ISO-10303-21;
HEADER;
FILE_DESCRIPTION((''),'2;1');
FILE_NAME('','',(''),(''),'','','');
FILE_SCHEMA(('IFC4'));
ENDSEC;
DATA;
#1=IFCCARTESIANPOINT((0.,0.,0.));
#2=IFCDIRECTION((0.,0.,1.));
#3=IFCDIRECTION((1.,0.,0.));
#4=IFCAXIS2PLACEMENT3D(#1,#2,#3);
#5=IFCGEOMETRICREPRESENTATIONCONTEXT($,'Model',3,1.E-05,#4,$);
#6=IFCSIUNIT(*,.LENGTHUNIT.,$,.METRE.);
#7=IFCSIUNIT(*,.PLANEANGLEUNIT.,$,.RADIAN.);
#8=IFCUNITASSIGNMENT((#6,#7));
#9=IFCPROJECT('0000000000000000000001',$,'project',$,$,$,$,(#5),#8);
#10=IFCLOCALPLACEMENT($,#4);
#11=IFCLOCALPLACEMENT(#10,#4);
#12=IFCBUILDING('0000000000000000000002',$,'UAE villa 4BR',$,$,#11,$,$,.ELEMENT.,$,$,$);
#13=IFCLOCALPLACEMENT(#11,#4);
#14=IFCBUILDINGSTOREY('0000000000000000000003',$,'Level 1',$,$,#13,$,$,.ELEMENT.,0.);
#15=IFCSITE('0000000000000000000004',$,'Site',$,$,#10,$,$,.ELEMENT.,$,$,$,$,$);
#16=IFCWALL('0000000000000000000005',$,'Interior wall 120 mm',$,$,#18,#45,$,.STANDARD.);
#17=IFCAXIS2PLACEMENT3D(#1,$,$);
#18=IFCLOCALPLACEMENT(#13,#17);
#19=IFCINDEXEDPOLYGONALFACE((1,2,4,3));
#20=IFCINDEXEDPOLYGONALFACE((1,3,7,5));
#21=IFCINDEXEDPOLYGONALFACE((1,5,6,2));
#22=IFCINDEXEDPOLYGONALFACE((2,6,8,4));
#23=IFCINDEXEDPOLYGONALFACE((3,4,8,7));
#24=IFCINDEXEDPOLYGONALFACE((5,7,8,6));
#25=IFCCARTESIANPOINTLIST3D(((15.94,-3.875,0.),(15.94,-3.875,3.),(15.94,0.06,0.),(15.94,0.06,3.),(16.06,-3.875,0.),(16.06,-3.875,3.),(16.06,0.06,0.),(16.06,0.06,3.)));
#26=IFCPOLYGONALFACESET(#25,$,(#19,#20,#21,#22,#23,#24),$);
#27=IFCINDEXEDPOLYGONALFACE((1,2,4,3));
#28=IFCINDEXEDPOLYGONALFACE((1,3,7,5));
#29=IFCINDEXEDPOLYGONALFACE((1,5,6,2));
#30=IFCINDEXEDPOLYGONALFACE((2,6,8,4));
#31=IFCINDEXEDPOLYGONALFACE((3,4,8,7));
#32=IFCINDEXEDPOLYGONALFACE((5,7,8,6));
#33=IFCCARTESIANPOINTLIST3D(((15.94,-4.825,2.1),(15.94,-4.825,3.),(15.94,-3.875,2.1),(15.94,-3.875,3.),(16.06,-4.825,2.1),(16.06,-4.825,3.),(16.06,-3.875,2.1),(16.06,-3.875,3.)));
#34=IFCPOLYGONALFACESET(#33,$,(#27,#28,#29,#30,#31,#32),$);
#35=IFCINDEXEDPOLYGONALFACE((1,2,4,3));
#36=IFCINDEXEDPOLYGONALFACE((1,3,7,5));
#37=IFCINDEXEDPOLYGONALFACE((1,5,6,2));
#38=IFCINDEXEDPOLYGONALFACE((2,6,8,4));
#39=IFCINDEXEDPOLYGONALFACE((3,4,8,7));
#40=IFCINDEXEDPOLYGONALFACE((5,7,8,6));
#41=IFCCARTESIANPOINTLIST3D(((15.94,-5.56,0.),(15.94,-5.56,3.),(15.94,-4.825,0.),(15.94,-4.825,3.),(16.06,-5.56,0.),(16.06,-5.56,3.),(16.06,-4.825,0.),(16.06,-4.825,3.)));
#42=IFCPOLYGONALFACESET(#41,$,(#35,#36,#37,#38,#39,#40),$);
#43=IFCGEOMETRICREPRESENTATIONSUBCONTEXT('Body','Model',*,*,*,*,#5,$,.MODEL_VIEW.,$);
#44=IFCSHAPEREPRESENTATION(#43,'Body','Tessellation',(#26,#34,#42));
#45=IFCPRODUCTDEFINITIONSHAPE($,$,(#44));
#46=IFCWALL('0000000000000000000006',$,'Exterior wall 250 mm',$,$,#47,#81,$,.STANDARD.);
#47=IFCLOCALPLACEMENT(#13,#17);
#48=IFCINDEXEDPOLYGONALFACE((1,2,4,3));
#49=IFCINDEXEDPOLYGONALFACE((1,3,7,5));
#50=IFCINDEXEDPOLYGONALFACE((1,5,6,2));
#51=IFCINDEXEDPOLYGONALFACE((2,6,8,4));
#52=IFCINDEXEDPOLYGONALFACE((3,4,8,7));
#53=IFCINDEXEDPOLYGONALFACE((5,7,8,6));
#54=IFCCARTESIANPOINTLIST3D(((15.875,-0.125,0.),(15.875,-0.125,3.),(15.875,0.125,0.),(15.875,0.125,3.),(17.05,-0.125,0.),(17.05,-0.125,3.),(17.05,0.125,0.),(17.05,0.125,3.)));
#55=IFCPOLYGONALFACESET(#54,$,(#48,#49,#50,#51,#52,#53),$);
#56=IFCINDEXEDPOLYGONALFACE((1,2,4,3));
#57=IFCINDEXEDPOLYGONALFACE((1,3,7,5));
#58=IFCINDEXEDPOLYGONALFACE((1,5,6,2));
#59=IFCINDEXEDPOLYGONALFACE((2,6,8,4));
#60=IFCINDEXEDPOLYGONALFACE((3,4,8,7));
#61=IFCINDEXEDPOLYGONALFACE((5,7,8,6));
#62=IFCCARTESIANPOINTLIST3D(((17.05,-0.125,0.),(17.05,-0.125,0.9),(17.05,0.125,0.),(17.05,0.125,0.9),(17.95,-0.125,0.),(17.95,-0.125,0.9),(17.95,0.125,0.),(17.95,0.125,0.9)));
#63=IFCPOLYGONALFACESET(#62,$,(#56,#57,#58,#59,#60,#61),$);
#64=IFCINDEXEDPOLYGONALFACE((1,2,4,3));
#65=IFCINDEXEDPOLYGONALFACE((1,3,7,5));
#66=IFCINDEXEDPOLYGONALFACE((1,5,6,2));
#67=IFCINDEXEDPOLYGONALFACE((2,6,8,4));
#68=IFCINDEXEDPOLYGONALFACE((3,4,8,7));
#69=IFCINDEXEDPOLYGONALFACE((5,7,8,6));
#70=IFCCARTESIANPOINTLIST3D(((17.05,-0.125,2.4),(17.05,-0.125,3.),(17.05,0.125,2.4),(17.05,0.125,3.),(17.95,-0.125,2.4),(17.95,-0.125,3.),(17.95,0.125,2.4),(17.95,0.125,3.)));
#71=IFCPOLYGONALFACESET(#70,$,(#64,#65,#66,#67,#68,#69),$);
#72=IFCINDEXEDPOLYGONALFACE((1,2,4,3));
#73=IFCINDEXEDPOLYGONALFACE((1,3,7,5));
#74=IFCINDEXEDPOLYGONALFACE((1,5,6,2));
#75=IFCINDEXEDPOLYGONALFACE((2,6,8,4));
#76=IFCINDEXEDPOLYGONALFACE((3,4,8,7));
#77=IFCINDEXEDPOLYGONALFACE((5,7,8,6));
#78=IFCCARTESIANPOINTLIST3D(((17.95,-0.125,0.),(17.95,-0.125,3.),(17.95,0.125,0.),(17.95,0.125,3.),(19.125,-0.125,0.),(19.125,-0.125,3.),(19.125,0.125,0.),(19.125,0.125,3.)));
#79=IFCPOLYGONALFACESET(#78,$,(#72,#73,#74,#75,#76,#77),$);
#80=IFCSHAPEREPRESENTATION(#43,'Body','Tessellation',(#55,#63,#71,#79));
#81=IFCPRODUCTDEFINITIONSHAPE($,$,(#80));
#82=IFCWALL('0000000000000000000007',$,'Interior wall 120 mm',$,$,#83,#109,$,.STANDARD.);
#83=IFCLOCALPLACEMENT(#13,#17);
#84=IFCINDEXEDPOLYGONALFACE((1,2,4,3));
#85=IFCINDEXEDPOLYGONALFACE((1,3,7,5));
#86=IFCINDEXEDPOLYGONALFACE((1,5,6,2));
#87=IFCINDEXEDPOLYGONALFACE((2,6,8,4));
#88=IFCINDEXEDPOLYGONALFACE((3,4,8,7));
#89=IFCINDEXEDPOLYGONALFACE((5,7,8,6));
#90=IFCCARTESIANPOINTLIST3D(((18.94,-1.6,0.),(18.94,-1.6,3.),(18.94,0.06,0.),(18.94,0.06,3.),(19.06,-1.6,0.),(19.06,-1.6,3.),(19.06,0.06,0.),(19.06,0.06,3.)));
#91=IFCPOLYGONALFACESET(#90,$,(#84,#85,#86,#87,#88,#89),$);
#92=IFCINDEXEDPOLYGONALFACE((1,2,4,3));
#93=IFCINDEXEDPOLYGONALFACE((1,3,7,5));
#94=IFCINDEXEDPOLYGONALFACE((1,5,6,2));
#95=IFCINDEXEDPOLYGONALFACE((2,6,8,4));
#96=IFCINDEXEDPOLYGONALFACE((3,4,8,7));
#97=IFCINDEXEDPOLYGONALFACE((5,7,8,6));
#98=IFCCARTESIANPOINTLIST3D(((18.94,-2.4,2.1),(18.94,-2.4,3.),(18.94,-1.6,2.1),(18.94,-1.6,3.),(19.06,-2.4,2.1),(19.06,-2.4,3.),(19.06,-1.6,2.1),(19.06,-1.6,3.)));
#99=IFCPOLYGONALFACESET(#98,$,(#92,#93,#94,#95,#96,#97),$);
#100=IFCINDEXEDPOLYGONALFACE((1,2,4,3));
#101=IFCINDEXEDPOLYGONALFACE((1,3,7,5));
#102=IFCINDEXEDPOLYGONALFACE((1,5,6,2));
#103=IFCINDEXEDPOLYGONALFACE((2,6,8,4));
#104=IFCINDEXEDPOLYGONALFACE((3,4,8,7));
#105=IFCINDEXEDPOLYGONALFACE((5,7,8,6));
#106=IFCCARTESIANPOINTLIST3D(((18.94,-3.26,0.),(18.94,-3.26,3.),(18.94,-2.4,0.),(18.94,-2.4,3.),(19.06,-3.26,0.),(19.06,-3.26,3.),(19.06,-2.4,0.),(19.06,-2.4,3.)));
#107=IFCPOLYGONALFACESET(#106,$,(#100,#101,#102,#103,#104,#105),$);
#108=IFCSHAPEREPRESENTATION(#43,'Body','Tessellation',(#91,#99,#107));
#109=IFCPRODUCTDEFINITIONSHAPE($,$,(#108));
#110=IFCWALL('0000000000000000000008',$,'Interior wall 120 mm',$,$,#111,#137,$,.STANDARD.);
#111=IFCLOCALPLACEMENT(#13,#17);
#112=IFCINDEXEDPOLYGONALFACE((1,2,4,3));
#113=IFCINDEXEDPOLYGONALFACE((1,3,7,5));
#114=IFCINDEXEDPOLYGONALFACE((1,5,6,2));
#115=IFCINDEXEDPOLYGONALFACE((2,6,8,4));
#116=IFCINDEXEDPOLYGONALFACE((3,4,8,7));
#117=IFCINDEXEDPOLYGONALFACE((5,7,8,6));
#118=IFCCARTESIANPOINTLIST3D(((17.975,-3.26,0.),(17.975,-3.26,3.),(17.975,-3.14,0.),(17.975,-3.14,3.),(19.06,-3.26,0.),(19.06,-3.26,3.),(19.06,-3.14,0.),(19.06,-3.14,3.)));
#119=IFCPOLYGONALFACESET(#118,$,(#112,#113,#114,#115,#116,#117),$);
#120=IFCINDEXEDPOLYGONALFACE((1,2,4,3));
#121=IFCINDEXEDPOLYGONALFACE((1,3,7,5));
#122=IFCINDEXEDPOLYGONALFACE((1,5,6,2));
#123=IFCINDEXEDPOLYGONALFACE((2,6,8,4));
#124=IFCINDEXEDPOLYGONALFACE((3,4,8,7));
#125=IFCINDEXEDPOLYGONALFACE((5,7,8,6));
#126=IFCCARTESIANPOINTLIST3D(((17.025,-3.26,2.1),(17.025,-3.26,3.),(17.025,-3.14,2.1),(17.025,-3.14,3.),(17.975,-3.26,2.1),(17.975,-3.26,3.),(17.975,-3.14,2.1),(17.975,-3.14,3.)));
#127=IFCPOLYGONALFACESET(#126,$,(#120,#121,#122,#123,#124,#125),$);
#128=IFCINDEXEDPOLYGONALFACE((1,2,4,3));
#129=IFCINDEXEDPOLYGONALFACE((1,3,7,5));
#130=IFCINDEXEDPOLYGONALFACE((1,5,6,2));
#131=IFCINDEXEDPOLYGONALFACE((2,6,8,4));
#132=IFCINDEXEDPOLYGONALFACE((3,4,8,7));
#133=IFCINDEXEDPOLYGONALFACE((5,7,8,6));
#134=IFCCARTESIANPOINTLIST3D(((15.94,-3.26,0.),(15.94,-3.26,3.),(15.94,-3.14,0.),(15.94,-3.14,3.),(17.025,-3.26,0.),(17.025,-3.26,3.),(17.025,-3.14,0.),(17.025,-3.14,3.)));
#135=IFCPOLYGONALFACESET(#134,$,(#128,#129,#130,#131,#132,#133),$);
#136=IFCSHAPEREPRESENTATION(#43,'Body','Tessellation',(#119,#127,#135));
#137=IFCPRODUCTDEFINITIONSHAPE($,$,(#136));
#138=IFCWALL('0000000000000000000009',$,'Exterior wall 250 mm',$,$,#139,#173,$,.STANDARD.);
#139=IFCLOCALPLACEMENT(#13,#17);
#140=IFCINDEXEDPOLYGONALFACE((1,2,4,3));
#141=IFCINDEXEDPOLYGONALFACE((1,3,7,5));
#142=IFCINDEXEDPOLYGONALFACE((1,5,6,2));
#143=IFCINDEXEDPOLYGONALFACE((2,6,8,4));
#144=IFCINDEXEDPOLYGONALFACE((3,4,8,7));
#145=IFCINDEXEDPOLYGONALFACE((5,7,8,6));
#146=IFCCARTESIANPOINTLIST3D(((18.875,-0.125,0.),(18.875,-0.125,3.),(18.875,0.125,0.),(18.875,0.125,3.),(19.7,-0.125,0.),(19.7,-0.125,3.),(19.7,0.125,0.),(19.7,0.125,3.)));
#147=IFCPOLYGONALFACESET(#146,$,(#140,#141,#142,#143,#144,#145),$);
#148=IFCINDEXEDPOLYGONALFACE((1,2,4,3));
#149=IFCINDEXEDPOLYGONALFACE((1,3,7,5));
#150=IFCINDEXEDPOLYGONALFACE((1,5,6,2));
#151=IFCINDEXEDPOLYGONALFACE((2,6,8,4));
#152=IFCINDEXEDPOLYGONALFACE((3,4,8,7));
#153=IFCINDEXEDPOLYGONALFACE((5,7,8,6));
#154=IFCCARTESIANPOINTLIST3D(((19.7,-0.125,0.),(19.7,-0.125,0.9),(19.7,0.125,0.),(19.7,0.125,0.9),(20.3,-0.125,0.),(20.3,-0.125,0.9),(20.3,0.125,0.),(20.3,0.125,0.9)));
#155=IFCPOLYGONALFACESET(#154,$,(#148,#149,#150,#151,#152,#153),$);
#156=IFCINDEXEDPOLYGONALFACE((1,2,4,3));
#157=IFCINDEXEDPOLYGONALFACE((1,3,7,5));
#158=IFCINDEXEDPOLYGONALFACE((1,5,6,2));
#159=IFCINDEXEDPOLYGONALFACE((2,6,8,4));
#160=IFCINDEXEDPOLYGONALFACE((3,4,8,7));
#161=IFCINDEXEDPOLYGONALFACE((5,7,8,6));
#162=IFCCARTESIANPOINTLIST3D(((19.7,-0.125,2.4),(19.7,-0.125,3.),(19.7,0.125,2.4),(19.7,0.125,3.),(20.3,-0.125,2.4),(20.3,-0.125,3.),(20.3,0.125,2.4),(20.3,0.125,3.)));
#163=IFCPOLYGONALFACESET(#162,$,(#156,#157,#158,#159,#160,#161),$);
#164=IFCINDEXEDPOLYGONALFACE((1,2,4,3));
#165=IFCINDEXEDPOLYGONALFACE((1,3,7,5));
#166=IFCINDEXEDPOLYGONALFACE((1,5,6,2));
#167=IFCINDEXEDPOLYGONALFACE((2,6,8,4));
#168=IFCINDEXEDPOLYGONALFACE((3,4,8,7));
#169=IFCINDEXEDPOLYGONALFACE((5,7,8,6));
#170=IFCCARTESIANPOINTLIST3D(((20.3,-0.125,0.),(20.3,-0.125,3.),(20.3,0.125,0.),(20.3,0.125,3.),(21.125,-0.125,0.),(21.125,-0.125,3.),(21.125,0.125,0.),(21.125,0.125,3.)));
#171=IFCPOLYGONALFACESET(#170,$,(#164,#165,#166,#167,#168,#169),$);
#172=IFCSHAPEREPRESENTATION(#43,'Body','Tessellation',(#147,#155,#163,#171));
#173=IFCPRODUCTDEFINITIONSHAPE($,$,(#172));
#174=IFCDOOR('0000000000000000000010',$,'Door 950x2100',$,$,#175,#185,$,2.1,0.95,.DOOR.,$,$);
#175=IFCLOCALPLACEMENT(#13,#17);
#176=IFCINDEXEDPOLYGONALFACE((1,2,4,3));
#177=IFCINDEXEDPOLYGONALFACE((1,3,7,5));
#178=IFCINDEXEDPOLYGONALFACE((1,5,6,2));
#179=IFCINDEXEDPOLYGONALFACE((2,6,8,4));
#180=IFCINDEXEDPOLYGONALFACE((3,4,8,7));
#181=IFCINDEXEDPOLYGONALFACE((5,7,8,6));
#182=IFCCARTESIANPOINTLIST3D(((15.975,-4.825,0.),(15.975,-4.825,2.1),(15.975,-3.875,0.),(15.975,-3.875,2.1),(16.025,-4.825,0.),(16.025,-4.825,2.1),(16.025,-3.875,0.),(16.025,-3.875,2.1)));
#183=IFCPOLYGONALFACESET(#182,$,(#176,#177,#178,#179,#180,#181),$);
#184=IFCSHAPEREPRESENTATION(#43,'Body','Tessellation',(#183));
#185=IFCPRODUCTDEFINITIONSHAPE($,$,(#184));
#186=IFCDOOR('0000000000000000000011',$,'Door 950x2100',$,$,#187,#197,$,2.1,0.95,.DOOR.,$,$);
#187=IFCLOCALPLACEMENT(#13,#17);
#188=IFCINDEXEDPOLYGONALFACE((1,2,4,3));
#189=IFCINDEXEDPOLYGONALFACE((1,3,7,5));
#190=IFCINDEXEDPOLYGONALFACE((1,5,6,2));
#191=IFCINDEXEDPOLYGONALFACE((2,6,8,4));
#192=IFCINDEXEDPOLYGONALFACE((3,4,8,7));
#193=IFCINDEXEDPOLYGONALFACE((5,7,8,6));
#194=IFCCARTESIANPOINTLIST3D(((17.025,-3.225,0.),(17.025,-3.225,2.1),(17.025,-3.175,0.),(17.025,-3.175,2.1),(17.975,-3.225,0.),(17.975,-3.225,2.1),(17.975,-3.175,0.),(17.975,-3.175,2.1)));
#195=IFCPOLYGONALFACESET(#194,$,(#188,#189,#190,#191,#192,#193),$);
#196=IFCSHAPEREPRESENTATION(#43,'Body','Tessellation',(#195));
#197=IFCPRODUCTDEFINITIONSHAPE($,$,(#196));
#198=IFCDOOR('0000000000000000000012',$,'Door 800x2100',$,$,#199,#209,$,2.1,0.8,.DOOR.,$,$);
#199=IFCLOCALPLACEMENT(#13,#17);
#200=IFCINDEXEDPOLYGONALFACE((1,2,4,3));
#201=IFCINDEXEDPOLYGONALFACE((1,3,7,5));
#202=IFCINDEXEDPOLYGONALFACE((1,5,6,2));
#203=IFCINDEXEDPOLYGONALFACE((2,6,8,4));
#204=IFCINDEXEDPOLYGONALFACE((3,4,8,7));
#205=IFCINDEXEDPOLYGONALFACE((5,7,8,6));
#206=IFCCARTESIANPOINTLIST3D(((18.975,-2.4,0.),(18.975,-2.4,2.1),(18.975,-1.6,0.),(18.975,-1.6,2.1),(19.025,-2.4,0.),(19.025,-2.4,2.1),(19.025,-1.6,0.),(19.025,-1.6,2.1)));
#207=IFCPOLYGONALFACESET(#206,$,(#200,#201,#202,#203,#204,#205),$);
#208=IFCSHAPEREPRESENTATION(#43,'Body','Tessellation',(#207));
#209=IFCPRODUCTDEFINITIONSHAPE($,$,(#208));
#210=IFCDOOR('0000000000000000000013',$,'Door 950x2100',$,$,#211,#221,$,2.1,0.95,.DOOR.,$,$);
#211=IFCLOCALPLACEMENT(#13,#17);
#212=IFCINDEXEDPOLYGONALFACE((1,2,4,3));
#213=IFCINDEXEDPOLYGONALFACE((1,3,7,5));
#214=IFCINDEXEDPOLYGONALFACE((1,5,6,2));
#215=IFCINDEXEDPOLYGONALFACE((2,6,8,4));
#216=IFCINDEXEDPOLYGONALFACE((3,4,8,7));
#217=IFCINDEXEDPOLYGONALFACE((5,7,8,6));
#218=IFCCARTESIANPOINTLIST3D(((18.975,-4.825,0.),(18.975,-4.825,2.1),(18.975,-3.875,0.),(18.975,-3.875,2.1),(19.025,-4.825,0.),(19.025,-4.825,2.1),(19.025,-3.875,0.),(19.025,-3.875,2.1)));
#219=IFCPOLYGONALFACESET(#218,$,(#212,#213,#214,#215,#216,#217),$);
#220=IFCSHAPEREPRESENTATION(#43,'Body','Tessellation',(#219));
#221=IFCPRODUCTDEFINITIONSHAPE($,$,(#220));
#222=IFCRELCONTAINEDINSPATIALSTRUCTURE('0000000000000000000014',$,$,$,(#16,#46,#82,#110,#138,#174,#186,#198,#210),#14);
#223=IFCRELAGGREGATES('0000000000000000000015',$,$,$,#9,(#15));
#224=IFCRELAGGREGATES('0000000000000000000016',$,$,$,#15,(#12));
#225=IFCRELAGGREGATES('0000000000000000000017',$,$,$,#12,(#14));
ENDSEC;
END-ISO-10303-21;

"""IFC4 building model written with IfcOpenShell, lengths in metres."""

from ifc_helpers import new_model, si_unit, frame, origin, origin_with_axes, origin_2d, place, context, subcontext, project, spatial, rectangle, extrude, element, save


model = new_model("IFC4")

# Units and contexts
model_context = context("Model", 3, precision=1e-05, world=origin_with_axes())
body_context = subcontext(model_context, "Body", "Model", "MODEL_VIEW")
ifc_project = project(units=[si_unit("LENGTHUNIT", "METRE"), si_unit("PLANEANGLEUNIT", "RADIAN")], contexts=[model_context])

# Site, building, storey
site_placement = place(None, origin_with_axes())
site = spatial("IfcSite", under=ifc_project, at=site_placement, Name="Site", CompositionType="ELEMENT")
building_placement = place(site_placement, origin_with_axes())
building = spatial("IfcBuilding", under=site, at=building_placement, Name="UAE villa 4BR", CompositionType="ELEMENT")
storey_placement = place(building_placement, origin_with_axes())
storey = spatial("IfcBuildingStorey", under=building, at=storey_placement, Name="Level 1", CompositionType="ELEMENT", Elevation=0.0)

# Walls
wall_1_placement = place(storey_placement, frame((16.0, 0.0, 0.0), z_axis=(0.0, 0.0, 1.0), x_axis=(0.0, -1.0, 0.0)))
element("IfcWall", 1, at=wall_1_placement, inside=storey, Name="Interior wall 120 mm", PredefinedType="STANDARD", context=body_context, shape_type="SweptSolid", body=[
    extrude(rectangle(XDim=3.935, YDim=0.12, at=origin_2d()), frame((1.9075, 0.0, 0.0)), (0.0, 0.0, 1.0), 3.0),
    extrude(rectangle(XDim=0.95, YDim=0.12, at=origin_2d()), frame((4.35, 0.0, 2.1)), (0.0, 0.0, 1.0), 0.9),
    extrude(rectangle(XDim=0.735, YDim=0.12, at=origin_2d()), frame((5.1925, 0.0, 0.0)), (0.0, 0.0, 1.0), 3.0),
])
wall_2_placement = place(storey_placement, frame((16.0, 0.0, 0.0), z_axis=(0.0, 0.0, 1.0), x_axis=(1.0, 0.0, 0.0)))
element("IfcWall", 2, at=wall_2_placement, inside=storey, Name="Exterior wall 250 mm", PredefinedType="STANDARD", context=body_context, shape_type="SweptSolid", body=[
    extrude(rectangle(XDim=1.175, YDim=0.25, at=origin_2d()), frame((0.4625, 0.0, 0.0)), (0.0, 0.0, 1.0), 3.0),
    extrude(rectangle(XDim=0.9, YDim=0.25, at=origin_2d()), frame((1.5, 0.0, 0.0)), (0.0, 0.0, 1.0), 0.9),
    extrude(rectangle(XDim=0.9, YDim=0.25, at=origin_2d()), frame((1.5, 0.0, 2.4)), (0.0, 0.0, 1.0), 0.6),
    extrude(rectangle(XDim=1.175, YDim=0.25, at=origin_2d()), frame((2.5375, 0.0, 0.0)), (0.0, 0.0, 1.0), 3.0),
])
wall_3_placement = place(storey_placement, frame((19.0, 0.0, 0.0), z_axis=(0.0, 0.0, 1.0), x_axis=(0.0, -1.0, 0.0)))
element("IfcWall", 3, at=wall_3_placement, inside=storey, Name="Interior wall 120 mm", PredefinedType="STANDARD", context=body_context, shape_type="SweptSolid", body=[
    extrude(rectangle(XDim=1.66, YDim=0.12, at=origin_2d()), frame((0.77, 0.0, 0.0)), (0.0, 0.0, 1.0), 3.0),
    extrude(rectangle(XDim=0.8, YDim=0.12, at=origin_2d()), frame((2.0, 0.0, 2.1)), (0.0, 0.0, 1.0), 0.9),
    extrude(rectangle(XDim=0.86, YDim=0.12, at=origin_2d()), frame((2.83, 0.0, 0.0)), (0.0, 0.0, 1.0), 3.0),
])
wall_4_placement = place(storey_placement, frame((19.0, -3.2, 0.0), z_axis=(0.0, 0.0, 1.0), x_axis=(-1.0, 0.0, 0.0)))
element("IfcWall", 4, at=wall_4_placement, inside=storey, Name="Interior wall 120 mm", PredefinedType="STANDARD", context=body_context, shape_type="SweptSolid", body=[
    extrude(rectangle(XDim=1.085, YDim=0.12, at=origin_2d()), frame((0.4825, 0.0, 0.0)), (0.0, 0.0, 1.0), 3.0),
    extrude(rectangle(XDim=0.95, YDim=0.12, at=origin_2d()), frame((1.5, 0.0, 2.1)), (0.0, 0.0, 1.0), 0.9),
    extrude(rectangle(XDim=1.085, YDim=0.12, at=origin_2d()), frame((2.5175, 0.0, 0.0)), (0.0, 0.0, 1.0), 3.0),
])
wall_5_placement = place(storey_placement, frame((19.0, 0.0, 0.0), z_axis=(0.0, 0.0, 1.0), x_axis=(1.0, 0.0, 0.0)))
element("IfcWall", 5, at=wall_5_placement, inside=storey, Name="Exterior wall 250 mm", PredefinedType="STANDARD", context=body_context, shape_type="SweptSolid", body=[
    extrude(rectangle(XDim=0.825, YDim=0.25, at=origin_2d()), frame((0.2875, 0.0, 0.0)), (0.0, 0.0, 1.0), 3.0),
    extrude(rectangle(XDim=0.6, YDim=0.25, at=origin_2d()), frame((1.0, 0.0, 0.0)), (0.0, 0.0, 1.0), 0.9),
    extrude(rectangle(XDim=0.6, YDim=0.25, at=origin_2d()), frame((1.0, 0.0, 2.4)), (0.0, 0.0, 1.0), 0.6),
    extrude(rectangle(XDim=0.825, YDim=0.25, at=origin_2d()), frame((1.7125, 0.0, 0.0)), (0.0, 0.0, 1.0), 3.0),
])

# Doors
for number, where, z_axis, x_axis, name in (
    (6, (16.0, -4.35, 0.0), (0.0, 0.0, 1.0), (0.0, -1.0, 0.0), "Door 950x2100"),
    (7, (17.5, -3.2, 0.0), (0.0, 0.0, 1.0), (-1.0, 0.0, 0.0), "Door 950x2100"),
):
    element("IfcDoor", number, at=place(storey_placement, frame(where, z_axis=z_axis, x_axis=x_axis)), inside=storey, Name=name, OverallHeight=2.1, OverallWidth=0.95, PredefinedType="DOOR", context=body_context, shape_type="SweptSolid", body=[
        extrude(rectangle(XDim=0.95, YDim=0.05, at=origin_2d()), origin(), (0.0, 0.0, 1.0), 2.1),
    ])
door_1_placement = place(storey_placement, frame((19.0, -2.0, 0.0), z_axis=(0.0, 0.0, 1.0), x_axis=(0.0, -1.0, 0.0)))
element("IfcDoor", 8, at=door_1_placement, inside=storey, Name="Door 800x2100", OverallHeight=2.1, OverallWidth=0.8, PredefinedType="DOOR", context=body_context, shape_type="SweptSolid", body=[
    extrude(rectangle(XDim=0.8, YDim=0.05, at=origin_2d()), origin(), (0.0, 0.0, 1.0), 2.1),
])
door_2_placement = place(storey_placement, frame((19.0, -4.35, 0.0), z_axis=(0.0, 0.0, 1.0), x_axis=(0.0, 1.0, 0.0)))
element("IfcDoor", 9, at=door_2_placement, inside=storey, Name="Door 950x2100", OverallHeight=2.1, OverallWidth=0.95, PredefinedType="DOOR", context=body_context, shape_type="SweptSolid", body=[
    extrude(rectangle(XDim=0.95, YDim=0.05, at=origin_2d()), origin(), (0.0, 0.0, 1.0), 2.1),
])

save(model, "model.ifc")
